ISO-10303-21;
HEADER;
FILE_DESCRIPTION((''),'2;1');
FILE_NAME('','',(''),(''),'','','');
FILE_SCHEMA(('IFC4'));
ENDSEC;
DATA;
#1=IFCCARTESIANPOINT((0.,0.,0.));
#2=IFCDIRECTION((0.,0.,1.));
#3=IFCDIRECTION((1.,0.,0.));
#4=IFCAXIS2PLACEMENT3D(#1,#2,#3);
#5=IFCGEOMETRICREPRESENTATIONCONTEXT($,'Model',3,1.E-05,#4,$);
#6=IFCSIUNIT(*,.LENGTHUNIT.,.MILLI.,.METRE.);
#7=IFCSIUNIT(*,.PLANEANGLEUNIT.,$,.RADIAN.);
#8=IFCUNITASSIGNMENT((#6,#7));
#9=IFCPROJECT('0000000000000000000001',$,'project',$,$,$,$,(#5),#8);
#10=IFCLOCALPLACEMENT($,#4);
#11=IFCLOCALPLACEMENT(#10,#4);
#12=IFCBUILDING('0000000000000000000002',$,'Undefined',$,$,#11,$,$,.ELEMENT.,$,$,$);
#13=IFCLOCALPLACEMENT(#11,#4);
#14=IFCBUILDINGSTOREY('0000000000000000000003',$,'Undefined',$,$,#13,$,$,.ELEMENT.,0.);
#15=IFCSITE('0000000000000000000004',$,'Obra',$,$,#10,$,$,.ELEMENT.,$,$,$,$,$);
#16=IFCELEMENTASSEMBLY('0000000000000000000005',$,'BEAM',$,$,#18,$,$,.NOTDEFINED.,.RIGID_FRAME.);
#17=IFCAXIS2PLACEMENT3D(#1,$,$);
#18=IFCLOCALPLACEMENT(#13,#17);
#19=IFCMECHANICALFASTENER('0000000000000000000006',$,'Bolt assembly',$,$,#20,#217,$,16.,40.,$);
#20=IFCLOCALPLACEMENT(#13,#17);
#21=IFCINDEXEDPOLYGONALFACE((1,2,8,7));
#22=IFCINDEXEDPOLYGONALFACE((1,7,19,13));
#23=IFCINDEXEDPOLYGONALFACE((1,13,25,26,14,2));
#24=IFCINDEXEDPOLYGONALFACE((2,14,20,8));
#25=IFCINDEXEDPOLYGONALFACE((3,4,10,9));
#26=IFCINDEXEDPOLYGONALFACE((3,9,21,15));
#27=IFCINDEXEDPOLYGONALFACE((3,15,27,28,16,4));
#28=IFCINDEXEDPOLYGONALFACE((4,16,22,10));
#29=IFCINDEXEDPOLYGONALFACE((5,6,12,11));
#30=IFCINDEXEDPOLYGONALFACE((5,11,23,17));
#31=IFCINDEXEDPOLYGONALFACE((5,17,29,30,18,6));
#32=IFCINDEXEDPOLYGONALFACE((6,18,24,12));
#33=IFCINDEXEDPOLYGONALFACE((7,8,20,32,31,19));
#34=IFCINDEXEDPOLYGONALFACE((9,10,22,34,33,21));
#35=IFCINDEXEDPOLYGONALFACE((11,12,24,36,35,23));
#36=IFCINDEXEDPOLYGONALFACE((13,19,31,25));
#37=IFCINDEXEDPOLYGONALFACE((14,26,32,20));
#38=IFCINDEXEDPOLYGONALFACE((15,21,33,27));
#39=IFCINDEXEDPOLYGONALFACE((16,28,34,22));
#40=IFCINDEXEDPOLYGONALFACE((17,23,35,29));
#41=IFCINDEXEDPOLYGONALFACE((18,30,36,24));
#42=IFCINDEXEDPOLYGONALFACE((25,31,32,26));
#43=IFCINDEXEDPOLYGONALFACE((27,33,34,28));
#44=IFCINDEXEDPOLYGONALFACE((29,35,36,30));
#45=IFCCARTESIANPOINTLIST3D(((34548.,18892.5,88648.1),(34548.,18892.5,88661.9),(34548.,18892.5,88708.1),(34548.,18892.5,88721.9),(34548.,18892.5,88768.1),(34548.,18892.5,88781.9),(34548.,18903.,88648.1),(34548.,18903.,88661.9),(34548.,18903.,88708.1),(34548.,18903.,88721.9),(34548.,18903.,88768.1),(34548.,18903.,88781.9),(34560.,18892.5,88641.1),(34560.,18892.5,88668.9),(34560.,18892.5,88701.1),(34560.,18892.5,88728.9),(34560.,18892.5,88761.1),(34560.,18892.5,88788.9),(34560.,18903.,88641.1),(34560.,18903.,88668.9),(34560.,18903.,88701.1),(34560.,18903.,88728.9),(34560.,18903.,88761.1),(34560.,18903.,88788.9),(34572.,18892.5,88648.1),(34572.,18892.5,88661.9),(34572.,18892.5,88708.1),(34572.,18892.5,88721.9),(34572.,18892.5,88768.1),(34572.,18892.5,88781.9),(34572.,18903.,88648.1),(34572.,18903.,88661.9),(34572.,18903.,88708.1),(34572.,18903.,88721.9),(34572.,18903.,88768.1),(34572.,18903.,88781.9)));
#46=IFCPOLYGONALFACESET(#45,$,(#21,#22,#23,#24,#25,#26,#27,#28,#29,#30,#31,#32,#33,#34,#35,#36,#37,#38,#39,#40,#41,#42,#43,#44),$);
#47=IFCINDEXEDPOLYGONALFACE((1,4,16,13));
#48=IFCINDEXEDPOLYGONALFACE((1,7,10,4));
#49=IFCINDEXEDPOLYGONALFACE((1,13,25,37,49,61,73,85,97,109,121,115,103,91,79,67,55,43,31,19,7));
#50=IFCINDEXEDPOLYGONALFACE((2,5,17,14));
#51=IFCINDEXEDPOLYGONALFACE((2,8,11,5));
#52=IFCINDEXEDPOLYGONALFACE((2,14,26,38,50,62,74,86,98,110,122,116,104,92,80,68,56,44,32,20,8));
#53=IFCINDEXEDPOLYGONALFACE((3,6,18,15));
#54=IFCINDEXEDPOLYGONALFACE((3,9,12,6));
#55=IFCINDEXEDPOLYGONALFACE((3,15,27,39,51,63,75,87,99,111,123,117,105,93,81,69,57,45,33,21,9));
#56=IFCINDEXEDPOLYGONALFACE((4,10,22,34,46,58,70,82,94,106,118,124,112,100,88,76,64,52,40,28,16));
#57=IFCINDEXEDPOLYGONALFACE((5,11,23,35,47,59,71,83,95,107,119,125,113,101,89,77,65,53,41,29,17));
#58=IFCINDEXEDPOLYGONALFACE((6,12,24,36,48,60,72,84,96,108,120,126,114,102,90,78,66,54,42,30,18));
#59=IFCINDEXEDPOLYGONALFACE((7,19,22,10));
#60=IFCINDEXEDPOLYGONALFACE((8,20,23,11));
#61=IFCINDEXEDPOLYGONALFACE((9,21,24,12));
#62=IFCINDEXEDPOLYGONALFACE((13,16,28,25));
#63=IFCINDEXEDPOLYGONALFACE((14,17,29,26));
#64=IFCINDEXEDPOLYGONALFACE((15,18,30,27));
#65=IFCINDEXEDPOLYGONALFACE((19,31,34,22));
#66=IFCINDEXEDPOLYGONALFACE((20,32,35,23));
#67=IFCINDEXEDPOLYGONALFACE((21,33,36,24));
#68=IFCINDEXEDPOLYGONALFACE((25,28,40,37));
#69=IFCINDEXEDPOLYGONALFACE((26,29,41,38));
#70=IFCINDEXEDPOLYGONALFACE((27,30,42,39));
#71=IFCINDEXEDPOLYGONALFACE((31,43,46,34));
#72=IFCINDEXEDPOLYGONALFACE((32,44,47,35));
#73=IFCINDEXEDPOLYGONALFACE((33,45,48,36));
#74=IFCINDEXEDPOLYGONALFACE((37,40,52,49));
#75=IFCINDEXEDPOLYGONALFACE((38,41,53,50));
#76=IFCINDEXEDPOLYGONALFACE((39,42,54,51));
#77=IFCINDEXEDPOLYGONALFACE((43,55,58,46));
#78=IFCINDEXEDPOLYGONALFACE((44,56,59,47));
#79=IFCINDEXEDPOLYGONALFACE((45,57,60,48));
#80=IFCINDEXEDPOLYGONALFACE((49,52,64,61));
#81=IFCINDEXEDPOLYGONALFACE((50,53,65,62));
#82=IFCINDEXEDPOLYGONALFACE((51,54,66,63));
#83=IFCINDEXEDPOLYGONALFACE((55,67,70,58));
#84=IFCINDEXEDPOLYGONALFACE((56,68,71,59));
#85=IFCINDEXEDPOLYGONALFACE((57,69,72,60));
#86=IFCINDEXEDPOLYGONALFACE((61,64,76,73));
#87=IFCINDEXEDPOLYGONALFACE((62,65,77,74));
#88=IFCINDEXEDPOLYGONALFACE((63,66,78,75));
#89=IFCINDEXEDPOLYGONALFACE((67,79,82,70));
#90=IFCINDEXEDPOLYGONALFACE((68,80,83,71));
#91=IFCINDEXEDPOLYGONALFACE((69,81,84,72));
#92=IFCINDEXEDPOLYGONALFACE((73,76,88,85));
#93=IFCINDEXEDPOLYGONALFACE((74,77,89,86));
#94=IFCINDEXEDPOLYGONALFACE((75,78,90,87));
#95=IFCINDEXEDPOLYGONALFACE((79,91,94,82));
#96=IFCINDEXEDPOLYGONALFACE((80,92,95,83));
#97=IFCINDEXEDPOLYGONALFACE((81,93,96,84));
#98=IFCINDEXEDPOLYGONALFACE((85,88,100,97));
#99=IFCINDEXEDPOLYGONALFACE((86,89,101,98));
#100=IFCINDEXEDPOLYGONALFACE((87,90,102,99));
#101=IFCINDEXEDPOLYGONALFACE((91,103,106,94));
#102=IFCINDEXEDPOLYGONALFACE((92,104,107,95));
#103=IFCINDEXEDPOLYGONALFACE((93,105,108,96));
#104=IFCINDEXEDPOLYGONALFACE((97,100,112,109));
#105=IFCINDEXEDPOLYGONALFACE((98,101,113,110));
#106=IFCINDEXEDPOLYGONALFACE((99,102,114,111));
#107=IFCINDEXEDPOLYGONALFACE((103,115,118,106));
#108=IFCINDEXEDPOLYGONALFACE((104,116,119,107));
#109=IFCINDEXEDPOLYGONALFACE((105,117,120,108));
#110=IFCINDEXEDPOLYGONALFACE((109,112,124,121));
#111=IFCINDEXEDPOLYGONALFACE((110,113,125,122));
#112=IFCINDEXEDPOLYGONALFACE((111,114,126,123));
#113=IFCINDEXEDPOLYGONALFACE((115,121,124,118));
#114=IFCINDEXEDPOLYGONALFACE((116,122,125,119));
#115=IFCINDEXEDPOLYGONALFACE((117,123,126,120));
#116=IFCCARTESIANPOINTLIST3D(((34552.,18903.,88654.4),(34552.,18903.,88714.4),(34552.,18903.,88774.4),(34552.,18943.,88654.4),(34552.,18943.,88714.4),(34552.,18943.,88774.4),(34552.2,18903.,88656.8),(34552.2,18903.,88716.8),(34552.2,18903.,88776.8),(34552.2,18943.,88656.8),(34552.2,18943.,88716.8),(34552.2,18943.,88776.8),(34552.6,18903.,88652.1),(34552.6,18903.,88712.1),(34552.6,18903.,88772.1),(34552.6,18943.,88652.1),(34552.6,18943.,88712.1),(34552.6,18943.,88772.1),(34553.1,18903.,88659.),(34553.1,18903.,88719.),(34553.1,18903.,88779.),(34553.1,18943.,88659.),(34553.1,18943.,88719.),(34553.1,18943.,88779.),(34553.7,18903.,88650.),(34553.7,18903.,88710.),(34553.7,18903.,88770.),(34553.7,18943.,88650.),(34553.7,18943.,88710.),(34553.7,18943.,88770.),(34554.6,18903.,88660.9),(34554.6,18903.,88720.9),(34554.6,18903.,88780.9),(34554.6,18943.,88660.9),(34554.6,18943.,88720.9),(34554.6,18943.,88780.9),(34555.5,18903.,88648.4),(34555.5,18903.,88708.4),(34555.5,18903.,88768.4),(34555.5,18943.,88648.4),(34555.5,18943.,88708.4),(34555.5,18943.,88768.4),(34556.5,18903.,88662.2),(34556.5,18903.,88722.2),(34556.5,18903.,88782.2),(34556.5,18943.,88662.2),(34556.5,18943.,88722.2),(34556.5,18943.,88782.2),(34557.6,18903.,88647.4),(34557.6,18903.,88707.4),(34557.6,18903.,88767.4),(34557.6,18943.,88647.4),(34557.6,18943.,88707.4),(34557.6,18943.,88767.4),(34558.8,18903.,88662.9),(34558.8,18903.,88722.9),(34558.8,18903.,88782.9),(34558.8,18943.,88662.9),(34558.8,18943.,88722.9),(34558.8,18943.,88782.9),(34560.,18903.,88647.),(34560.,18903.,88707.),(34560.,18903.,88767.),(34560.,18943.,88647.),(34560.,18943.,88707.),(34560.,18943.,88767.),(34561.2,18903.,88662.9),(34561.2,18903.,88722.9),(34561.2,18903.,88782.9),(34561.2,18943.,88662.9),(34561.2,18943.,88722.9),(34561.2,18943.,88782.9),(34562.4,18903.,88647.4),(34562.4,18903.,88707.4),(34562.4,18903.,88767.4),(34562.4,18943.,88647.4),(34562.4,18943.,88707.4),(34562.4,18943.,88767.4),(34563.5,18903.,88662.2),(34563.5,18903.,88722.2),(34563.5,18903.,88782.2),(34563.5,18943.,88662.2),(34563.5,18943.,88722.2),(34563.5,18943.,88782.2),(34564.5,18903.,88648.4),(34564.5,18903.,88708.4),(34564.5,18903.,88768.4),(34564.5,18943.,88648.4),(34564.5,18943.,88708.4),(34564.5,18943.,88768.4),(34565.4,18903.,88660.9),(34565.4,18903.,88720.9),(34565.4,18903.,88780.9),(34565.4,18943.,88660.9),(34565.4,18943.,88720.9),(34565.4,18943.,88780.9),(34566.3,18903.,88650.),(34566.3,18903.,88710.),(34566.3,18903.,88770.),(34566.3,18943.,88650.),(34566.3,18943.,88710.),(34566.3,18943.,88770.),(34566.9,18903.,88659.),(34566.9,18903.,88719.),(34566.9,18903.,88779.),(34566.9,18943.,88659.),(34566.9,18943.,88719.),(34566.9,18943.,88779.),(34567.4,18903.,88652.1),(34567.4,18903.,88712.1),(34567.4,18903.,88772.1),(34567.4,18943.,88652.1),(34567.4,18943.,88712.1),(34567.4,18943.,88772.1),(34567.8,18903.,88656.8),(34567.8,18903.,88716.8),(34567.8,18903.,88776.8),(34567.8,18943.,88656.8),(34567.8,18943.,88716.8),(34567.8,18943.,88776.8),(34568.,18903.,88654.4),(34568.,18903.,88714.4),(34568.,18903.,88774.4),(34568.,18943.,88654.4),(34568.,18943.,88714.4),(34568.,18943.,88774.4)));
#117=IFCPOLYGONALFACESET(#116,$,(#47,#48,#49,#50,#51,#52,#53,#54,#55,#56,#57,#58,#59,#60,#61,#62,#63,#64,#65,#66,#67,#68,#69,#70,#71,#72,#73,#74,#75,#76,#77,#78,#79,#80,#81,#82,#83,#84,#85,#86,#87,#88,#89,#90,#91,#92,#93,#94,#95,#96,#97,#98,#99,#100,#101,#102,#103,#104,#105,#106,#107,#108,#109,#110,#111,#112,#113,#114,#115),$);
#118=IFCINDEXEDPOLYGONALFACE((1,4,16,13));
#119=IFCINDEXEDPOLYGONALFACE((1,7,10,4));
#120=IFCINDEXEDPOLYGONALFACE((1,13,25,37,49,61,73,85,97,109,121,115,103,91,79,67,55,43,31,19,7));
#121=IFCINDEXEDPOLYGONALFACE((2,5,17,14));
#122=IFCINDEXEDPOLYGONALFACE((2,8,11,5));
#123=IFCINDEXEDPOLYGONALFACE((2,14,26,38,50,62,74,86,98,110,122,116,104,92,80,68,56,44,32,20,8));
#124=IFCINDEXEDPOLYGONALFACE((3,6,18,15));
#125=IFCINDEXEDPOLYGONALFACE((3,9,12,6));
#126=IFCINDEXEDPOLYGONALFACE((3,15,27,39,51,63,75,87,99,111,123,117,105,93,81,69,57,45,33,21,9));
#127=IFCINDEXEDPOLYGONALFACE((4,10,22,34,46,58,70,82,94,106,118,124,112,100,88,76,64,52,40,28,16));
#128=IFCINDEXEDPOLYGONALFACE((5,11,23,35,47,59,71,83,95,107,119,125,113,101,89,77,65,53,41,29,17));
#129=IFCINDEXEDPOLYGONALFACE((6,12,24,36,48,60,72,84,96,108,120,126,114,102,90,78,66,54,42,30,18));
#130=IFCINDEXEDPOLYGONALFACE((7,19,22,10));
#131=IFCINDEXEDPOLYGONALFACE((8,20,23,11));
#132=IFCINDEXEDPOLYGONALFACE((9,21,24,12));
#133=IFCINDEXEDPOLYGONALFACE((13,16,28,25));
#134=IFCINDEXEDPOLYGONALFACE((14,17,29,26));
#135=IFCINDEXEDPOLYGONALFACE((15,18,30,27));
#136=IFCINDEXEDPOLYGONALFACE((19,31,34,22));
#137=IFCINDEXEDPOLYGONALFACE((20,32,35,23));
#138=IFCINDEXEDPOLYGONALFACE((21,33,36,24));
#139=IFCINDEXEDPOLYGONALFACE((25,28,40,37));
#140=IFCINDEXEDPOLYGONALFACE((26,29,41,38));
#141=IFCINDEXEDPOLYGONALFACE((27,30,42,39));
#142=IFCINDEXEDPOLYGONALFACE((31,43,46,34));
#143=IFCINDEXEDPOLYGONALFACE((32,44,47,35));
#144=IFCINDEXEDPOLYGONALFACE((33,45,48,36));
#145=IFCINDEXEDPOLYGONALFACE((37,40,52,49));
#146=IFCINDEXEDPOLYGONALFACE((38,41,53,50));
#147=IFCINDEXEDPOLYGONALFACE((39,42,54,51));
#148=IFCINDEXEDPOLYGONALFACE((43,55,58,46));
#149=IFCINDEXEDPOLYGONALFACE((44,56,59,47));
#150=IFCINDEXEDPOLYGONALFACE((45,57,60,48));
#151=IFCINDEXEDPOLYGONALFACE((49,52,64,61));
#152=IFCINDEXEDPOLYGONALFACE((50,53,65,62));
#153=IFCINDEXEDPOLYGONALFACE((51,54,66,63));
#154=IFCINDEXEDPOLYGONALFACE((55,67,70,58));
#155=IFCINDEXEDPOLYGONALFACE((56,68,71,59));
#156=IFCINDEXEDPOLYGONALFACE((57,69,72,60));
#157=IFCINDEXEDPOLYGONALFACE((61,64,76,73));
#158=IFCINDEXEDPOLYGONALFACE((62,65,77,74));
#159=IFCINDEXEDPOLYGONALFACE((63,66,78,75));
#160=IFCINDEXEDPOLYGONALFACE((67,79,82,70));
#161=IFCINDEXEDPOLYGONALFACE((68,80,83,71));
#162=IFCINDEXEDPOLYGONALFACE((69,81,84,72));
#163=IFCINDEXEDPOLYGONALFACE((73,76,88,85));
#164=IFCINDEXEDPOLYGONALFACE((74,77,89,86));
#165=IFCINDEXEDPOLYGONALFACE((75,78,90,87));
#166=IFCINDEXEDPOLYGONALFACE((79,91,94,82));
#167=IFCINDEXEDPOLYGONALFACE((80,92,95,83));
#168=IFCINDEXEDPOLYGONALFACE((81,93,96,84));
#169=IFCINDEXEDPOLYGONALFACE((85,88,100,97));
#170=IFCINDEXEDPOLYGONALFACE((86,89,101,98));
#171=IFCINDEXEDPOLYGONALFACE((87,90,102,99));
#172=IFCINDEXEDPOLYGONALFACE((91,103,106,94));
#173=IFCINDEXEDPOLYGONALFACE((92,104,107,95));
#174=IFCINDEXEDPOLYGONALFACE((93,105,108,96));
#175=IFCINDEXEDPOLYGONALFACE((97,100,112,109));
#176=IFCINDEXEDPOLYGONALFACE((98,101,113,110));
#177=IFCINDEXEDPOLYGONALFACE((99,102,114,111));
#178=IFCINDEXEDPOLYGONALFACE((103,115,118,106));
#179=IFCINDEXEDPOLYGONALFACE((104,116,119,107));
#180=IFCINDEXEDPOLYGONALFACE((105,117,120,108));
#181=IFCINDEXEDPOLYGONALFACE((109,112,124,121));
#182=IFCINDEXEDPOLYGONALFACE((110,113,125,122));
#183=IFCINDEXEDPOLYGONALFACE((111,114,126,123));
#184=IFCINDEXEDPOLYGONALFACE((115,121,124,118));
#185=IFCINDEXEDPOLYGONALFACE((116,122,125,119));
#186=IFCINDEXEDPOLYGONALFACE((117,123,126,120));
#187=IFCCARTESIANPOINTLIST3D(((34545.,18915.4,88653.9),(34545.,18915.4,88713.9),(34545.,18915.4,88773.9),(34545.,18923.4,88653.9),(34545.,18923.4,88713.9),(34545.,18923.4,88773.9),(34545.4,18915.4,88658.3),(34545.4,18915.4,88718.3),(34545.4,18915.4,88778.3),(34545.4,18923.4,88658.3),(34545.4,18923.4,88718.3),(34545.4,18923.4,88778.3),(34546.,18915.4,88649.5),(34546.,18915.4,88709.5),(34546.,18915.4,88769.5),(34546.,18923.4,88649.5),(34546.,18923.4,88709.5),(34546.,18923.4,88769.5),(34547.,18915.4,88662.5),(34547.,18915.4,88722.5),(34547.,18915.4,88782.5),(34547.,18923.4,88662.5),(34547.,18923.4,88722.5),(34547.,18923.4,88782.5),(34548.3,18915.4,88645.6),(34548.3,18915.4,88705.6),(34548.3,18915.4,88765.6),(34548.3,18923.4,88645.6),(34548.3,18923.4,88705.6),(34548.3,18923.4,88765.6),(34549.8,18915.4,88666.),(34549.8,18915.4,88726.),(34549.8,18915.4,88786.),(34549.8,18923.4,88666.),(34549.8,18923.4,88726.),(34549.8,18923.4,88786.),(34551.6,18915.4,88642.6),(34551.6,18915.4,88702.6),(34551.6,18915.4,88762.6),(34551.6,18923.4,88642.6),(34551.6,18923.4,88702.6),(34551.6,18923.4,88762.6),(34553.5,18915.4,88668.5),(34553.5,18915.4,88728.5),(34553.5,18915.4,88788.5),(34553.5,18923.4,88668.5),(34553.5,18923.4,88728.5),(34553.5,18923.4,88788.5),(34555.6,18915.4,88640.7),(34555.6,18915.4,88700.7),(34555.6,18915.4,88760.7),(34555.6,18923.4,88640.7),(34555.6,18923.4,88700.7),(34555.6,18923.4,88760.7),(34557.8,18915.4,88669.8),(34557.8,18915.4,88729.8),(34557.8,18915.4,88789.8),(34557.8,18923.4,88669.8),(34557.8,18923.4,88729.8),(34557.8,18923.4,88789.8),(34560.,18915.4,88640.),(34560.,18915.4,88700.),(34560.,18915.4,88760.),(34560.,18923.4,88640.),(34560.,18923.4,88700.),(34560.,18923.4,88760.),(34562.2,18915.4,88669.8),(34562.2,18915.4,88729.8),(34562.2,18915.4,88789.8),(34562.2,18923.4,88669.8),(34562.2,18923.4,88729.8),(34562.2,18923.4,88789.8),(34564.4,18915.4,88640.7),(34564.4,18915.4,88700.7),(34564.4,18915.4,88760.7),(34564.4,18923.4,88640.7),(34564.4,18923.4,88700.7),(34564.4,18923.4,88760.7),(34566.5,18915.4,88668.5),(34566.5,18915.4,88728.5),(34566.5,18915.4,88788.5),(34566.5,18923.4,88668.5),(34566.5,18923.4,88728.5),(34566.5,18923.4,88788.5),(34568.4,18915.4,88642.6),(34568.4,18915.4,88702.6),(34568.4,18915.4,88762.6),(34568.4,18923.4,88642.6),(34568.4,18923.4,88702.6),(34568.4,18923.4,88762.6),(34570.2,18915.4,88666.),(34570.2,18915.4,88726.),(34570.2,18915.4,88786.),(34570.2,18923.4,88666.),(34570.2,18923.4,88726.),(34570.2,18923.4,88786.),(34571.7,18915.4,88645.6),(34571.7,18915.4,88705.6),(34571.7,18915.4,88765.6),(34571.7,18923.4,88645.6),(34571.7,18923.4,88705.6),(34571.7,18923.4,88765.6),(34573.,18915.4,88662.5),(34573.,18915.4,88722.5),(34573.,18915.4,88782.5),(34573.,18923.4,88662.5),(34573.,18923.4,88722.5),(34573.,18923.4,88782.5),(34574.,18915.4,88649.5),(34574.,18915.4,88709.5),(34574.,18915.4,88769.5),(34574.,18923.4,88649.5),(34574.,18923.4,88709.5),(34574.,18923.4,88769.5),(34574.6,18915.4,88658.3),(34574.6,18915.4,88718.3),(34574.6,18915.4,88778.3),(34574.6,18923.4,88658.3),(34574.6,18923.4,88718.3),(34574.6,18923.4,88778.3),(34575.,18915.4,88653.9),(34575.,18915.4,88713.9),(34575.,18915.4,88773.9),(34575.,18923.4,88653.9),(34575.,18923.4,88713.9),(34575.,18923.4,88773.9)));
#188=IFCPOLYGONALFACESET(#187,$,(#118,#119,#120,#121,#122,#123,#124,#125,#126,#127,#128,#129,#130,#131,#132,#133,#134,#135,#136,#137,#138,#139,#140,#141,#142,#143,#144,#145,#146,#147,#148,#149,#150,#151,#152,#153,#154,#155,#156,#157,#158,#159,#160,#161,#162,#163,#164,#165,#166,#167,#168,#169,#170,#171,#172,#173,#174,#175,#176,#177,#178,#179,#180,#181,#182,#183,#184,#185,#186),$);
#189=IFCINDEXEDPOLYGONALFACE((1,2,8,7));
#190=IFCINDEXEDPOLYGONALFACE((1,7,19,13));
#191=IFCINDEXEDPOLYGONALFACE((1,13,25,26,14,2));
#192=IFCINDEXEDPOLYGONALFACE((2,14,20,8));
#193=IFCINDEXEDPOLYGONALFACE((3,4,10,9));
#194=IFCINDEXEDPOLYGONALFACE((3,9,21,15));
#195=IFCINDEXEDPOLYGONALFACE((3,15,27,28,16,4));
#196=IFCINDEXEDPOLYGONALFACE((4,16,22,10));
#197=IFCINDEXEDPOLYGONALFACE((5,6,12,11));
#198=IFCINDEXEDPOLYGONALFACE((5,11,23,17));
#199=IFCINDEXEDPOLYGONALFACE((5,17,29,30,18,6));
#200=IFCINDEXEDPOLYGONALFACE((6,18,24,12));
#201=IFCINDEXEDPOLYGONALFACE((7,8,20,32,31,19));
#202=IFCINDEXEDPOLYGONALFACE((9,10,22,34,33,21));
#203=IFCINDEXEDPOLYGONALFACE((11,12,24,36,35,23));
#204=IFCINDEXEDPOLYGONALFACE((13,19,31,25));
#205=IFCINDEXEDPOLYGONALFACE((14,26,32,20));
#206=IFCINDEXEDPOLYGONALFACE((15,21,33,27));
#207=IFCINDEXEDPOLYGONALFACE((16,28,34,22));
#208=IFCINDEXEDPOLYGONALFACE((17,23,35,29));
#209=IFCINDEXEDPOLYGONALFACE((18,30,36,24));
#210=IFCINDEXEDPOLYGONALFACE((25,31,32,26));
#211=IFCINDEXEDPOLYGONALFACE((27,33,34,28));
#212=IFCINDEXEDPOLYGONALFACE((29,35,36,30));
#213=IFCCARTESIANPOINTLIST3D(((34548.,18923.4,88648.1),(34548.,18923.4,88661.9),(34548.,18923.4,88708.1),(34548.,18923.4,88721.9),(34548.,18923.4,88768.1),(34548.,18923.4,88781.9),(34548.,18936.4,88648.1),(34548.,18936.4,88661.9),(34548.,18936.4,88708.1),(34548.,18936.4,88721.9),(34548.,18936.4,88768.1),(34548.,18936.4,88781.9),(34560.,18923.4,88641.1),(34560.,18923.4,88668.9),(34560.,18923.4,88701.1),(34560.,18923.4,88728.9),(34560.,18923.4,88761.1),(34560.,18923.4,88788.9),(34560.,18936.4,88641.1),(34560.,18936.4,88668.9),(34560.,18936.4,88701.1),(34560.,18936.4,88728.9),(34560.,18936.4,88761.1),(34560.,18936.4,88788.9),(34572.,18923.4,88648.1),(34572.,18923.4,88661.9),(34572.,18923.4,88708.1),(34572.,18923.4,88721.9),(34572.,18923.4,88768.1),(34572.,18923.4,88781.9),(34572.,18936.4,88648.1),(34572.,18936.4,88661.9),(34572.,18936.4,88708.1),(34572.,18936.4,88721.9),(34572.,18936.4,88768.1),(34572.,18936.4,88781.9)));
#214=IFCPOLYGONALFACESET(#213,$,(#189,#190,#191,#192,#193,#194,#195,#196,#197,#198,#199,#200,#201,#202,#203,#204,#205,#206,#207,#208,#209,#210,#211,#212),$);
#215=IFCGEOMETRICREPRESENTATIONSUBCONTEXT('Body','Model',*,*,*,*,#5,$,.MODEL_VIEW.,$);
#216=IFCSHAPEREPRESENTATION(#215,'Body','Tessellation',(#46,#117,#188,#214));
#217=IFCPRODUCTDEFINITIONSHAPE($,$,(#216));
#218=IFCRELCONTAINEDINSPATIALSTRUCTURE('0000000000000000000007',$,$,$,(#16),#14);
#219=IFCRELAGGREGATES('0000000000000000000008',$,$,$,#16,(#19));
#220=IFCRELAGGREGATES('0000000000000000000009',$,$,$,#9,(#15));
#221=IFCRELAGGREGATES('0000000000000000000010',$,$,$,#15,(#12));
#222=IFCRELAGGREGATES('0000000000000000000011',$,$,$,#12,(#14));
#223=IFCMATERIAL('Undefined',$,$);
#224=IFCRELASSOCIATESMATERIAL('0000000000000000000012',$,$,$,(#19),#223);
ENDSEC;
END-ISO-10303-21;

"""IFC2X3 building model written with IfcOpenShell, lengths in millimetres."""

from ifc_helpers import new_model, si_unit, frame, origin_with_axes, origin_2d_with_axis, place, context, subcontext, project, spatial, polyline, circle, outline, extrude, source, transform, mapped, material, element, aggregate, save


model = new_model("IFC2X3")

# Units and contexts
model_context = context("Model", 3, precision=1e-05, world=origin_with_axes())
body_context = subcontext(model_context, "Body", "Model", "MODEL_VIEW")
ifc_project = project(units=[si_unit("LENGTHUNIT", "METRE", prefix="MILLI"), si_unit("PLANEANGLEUNIT", "RADIAN")], contexts=[model_context])

# Site, building, storey
site_placement = place(None, origin_with_axes())
site = spatial("IfcSite", under=ifc_project, at=site_placement, Name="Obra", CompositionType="ELEMENT")
building_placement = place(site_placement, origin_with_axes())
building = spatial("IfcBuilding", under=site, at=building_placement, Name="Undefined", CompositionType="ELEMENT")
storey_placement = place(building_placement, origin_with_axes())
storey = spatial("IfcBuildingStorey", under=building, at=storey_placement, Name="Undefined", CompositionType="ELEMENT", Elevation=0.0)

# Element assembly, mechanical fastener
ifc_material_1 = material(Name="Undefined")
shared_shape_1 = source(origin_with_axes(), body_context, "Body", "SweptSolid", [
    extrude(outline(polyline([(13.9, 0.0), (6.9, 12.0), (-6.9, 12.0), (-13.9, 0.0), (-6.9, -12.0), (6.9, -12.0), (13.9, 0.0)])), frame((0.0, -19.7, 0.0), z_axis=(0.0, 1.0, 0.0), x_axis=(1.0, 0.0, 0.0)), (0.0, 0.0, 1.0), 10.6),
    extrude(circle(Radius=8.0, at=origin_2d_with_axis()), frame((0.0, -9.1, 0.0), z_axis=(0.0, 1.0, 0.0), x_axis=(1.0, 0.0, 0.0)), (0.0, 0.0, 1.0), 40.0),
    extrude(circle(Radius=15.0, at=origin_2d_with_axis()), frame((0.0, 3.3, 0.0), z_axis=(0.0, 1.0, 0.0), x_axis=(1.0, 0.0, 0.0)), (0.0, 0.0, 1.0), 8.0),
    extrude(outline(polyline([(13.9, 0.0), (6.9, 12.0), (-6.9, 12.0), (-13.9, 0.0), (-6.9, -12.0), (6.9, -12.0), (13.9, 0.0)])), frame((0.0, 11.3, 0.0), z_axis=(0.0, 1.0, 0.0), x_axis=(1.0, 0.0, 0.0)), (0.0, 0.0, 1.0), 13.0),
])
assembly_1_placement = place(storey_placement, origin_with_axes())
assembly_1 = element("IfcElementAssembly", 1, at=assembly_1_placement, inside=storey, Name="BEAM", AssemblyPlace="NOTDEFINED", PredefinedType="RIGID_FRAME")
mechanical_fastener_1_placement = place(assembly_1_placement, frame((34510.0, 18912.1, 88835.0), z_axis=(1.0, 0.0, 0.0), x_axis=(0.0, 0.0, -1.0)))
mechanical_fastener_1 = element("IfcMechanicalFastener", 2, at=mechanical_fastener_1_placement, material=ifc_material_1, Name="Bolt assembly", NominalDiameter=16.0, NominalLength=40.0, context=body_context, shape_type="MappedRepresentation", body=[
    mapped(shared_shape_1, transform((60.0, 0.0, 50.0))),
    mapped(shared_shape_1, transform((120.0, 0.0, 50.0))),
    mapped(shared_shape_1, transform((180.0, 0.0, 50.0))),
])
aggregate(assembly_1, [mechanical_fastener_1])

save(model, "model.ifc")
